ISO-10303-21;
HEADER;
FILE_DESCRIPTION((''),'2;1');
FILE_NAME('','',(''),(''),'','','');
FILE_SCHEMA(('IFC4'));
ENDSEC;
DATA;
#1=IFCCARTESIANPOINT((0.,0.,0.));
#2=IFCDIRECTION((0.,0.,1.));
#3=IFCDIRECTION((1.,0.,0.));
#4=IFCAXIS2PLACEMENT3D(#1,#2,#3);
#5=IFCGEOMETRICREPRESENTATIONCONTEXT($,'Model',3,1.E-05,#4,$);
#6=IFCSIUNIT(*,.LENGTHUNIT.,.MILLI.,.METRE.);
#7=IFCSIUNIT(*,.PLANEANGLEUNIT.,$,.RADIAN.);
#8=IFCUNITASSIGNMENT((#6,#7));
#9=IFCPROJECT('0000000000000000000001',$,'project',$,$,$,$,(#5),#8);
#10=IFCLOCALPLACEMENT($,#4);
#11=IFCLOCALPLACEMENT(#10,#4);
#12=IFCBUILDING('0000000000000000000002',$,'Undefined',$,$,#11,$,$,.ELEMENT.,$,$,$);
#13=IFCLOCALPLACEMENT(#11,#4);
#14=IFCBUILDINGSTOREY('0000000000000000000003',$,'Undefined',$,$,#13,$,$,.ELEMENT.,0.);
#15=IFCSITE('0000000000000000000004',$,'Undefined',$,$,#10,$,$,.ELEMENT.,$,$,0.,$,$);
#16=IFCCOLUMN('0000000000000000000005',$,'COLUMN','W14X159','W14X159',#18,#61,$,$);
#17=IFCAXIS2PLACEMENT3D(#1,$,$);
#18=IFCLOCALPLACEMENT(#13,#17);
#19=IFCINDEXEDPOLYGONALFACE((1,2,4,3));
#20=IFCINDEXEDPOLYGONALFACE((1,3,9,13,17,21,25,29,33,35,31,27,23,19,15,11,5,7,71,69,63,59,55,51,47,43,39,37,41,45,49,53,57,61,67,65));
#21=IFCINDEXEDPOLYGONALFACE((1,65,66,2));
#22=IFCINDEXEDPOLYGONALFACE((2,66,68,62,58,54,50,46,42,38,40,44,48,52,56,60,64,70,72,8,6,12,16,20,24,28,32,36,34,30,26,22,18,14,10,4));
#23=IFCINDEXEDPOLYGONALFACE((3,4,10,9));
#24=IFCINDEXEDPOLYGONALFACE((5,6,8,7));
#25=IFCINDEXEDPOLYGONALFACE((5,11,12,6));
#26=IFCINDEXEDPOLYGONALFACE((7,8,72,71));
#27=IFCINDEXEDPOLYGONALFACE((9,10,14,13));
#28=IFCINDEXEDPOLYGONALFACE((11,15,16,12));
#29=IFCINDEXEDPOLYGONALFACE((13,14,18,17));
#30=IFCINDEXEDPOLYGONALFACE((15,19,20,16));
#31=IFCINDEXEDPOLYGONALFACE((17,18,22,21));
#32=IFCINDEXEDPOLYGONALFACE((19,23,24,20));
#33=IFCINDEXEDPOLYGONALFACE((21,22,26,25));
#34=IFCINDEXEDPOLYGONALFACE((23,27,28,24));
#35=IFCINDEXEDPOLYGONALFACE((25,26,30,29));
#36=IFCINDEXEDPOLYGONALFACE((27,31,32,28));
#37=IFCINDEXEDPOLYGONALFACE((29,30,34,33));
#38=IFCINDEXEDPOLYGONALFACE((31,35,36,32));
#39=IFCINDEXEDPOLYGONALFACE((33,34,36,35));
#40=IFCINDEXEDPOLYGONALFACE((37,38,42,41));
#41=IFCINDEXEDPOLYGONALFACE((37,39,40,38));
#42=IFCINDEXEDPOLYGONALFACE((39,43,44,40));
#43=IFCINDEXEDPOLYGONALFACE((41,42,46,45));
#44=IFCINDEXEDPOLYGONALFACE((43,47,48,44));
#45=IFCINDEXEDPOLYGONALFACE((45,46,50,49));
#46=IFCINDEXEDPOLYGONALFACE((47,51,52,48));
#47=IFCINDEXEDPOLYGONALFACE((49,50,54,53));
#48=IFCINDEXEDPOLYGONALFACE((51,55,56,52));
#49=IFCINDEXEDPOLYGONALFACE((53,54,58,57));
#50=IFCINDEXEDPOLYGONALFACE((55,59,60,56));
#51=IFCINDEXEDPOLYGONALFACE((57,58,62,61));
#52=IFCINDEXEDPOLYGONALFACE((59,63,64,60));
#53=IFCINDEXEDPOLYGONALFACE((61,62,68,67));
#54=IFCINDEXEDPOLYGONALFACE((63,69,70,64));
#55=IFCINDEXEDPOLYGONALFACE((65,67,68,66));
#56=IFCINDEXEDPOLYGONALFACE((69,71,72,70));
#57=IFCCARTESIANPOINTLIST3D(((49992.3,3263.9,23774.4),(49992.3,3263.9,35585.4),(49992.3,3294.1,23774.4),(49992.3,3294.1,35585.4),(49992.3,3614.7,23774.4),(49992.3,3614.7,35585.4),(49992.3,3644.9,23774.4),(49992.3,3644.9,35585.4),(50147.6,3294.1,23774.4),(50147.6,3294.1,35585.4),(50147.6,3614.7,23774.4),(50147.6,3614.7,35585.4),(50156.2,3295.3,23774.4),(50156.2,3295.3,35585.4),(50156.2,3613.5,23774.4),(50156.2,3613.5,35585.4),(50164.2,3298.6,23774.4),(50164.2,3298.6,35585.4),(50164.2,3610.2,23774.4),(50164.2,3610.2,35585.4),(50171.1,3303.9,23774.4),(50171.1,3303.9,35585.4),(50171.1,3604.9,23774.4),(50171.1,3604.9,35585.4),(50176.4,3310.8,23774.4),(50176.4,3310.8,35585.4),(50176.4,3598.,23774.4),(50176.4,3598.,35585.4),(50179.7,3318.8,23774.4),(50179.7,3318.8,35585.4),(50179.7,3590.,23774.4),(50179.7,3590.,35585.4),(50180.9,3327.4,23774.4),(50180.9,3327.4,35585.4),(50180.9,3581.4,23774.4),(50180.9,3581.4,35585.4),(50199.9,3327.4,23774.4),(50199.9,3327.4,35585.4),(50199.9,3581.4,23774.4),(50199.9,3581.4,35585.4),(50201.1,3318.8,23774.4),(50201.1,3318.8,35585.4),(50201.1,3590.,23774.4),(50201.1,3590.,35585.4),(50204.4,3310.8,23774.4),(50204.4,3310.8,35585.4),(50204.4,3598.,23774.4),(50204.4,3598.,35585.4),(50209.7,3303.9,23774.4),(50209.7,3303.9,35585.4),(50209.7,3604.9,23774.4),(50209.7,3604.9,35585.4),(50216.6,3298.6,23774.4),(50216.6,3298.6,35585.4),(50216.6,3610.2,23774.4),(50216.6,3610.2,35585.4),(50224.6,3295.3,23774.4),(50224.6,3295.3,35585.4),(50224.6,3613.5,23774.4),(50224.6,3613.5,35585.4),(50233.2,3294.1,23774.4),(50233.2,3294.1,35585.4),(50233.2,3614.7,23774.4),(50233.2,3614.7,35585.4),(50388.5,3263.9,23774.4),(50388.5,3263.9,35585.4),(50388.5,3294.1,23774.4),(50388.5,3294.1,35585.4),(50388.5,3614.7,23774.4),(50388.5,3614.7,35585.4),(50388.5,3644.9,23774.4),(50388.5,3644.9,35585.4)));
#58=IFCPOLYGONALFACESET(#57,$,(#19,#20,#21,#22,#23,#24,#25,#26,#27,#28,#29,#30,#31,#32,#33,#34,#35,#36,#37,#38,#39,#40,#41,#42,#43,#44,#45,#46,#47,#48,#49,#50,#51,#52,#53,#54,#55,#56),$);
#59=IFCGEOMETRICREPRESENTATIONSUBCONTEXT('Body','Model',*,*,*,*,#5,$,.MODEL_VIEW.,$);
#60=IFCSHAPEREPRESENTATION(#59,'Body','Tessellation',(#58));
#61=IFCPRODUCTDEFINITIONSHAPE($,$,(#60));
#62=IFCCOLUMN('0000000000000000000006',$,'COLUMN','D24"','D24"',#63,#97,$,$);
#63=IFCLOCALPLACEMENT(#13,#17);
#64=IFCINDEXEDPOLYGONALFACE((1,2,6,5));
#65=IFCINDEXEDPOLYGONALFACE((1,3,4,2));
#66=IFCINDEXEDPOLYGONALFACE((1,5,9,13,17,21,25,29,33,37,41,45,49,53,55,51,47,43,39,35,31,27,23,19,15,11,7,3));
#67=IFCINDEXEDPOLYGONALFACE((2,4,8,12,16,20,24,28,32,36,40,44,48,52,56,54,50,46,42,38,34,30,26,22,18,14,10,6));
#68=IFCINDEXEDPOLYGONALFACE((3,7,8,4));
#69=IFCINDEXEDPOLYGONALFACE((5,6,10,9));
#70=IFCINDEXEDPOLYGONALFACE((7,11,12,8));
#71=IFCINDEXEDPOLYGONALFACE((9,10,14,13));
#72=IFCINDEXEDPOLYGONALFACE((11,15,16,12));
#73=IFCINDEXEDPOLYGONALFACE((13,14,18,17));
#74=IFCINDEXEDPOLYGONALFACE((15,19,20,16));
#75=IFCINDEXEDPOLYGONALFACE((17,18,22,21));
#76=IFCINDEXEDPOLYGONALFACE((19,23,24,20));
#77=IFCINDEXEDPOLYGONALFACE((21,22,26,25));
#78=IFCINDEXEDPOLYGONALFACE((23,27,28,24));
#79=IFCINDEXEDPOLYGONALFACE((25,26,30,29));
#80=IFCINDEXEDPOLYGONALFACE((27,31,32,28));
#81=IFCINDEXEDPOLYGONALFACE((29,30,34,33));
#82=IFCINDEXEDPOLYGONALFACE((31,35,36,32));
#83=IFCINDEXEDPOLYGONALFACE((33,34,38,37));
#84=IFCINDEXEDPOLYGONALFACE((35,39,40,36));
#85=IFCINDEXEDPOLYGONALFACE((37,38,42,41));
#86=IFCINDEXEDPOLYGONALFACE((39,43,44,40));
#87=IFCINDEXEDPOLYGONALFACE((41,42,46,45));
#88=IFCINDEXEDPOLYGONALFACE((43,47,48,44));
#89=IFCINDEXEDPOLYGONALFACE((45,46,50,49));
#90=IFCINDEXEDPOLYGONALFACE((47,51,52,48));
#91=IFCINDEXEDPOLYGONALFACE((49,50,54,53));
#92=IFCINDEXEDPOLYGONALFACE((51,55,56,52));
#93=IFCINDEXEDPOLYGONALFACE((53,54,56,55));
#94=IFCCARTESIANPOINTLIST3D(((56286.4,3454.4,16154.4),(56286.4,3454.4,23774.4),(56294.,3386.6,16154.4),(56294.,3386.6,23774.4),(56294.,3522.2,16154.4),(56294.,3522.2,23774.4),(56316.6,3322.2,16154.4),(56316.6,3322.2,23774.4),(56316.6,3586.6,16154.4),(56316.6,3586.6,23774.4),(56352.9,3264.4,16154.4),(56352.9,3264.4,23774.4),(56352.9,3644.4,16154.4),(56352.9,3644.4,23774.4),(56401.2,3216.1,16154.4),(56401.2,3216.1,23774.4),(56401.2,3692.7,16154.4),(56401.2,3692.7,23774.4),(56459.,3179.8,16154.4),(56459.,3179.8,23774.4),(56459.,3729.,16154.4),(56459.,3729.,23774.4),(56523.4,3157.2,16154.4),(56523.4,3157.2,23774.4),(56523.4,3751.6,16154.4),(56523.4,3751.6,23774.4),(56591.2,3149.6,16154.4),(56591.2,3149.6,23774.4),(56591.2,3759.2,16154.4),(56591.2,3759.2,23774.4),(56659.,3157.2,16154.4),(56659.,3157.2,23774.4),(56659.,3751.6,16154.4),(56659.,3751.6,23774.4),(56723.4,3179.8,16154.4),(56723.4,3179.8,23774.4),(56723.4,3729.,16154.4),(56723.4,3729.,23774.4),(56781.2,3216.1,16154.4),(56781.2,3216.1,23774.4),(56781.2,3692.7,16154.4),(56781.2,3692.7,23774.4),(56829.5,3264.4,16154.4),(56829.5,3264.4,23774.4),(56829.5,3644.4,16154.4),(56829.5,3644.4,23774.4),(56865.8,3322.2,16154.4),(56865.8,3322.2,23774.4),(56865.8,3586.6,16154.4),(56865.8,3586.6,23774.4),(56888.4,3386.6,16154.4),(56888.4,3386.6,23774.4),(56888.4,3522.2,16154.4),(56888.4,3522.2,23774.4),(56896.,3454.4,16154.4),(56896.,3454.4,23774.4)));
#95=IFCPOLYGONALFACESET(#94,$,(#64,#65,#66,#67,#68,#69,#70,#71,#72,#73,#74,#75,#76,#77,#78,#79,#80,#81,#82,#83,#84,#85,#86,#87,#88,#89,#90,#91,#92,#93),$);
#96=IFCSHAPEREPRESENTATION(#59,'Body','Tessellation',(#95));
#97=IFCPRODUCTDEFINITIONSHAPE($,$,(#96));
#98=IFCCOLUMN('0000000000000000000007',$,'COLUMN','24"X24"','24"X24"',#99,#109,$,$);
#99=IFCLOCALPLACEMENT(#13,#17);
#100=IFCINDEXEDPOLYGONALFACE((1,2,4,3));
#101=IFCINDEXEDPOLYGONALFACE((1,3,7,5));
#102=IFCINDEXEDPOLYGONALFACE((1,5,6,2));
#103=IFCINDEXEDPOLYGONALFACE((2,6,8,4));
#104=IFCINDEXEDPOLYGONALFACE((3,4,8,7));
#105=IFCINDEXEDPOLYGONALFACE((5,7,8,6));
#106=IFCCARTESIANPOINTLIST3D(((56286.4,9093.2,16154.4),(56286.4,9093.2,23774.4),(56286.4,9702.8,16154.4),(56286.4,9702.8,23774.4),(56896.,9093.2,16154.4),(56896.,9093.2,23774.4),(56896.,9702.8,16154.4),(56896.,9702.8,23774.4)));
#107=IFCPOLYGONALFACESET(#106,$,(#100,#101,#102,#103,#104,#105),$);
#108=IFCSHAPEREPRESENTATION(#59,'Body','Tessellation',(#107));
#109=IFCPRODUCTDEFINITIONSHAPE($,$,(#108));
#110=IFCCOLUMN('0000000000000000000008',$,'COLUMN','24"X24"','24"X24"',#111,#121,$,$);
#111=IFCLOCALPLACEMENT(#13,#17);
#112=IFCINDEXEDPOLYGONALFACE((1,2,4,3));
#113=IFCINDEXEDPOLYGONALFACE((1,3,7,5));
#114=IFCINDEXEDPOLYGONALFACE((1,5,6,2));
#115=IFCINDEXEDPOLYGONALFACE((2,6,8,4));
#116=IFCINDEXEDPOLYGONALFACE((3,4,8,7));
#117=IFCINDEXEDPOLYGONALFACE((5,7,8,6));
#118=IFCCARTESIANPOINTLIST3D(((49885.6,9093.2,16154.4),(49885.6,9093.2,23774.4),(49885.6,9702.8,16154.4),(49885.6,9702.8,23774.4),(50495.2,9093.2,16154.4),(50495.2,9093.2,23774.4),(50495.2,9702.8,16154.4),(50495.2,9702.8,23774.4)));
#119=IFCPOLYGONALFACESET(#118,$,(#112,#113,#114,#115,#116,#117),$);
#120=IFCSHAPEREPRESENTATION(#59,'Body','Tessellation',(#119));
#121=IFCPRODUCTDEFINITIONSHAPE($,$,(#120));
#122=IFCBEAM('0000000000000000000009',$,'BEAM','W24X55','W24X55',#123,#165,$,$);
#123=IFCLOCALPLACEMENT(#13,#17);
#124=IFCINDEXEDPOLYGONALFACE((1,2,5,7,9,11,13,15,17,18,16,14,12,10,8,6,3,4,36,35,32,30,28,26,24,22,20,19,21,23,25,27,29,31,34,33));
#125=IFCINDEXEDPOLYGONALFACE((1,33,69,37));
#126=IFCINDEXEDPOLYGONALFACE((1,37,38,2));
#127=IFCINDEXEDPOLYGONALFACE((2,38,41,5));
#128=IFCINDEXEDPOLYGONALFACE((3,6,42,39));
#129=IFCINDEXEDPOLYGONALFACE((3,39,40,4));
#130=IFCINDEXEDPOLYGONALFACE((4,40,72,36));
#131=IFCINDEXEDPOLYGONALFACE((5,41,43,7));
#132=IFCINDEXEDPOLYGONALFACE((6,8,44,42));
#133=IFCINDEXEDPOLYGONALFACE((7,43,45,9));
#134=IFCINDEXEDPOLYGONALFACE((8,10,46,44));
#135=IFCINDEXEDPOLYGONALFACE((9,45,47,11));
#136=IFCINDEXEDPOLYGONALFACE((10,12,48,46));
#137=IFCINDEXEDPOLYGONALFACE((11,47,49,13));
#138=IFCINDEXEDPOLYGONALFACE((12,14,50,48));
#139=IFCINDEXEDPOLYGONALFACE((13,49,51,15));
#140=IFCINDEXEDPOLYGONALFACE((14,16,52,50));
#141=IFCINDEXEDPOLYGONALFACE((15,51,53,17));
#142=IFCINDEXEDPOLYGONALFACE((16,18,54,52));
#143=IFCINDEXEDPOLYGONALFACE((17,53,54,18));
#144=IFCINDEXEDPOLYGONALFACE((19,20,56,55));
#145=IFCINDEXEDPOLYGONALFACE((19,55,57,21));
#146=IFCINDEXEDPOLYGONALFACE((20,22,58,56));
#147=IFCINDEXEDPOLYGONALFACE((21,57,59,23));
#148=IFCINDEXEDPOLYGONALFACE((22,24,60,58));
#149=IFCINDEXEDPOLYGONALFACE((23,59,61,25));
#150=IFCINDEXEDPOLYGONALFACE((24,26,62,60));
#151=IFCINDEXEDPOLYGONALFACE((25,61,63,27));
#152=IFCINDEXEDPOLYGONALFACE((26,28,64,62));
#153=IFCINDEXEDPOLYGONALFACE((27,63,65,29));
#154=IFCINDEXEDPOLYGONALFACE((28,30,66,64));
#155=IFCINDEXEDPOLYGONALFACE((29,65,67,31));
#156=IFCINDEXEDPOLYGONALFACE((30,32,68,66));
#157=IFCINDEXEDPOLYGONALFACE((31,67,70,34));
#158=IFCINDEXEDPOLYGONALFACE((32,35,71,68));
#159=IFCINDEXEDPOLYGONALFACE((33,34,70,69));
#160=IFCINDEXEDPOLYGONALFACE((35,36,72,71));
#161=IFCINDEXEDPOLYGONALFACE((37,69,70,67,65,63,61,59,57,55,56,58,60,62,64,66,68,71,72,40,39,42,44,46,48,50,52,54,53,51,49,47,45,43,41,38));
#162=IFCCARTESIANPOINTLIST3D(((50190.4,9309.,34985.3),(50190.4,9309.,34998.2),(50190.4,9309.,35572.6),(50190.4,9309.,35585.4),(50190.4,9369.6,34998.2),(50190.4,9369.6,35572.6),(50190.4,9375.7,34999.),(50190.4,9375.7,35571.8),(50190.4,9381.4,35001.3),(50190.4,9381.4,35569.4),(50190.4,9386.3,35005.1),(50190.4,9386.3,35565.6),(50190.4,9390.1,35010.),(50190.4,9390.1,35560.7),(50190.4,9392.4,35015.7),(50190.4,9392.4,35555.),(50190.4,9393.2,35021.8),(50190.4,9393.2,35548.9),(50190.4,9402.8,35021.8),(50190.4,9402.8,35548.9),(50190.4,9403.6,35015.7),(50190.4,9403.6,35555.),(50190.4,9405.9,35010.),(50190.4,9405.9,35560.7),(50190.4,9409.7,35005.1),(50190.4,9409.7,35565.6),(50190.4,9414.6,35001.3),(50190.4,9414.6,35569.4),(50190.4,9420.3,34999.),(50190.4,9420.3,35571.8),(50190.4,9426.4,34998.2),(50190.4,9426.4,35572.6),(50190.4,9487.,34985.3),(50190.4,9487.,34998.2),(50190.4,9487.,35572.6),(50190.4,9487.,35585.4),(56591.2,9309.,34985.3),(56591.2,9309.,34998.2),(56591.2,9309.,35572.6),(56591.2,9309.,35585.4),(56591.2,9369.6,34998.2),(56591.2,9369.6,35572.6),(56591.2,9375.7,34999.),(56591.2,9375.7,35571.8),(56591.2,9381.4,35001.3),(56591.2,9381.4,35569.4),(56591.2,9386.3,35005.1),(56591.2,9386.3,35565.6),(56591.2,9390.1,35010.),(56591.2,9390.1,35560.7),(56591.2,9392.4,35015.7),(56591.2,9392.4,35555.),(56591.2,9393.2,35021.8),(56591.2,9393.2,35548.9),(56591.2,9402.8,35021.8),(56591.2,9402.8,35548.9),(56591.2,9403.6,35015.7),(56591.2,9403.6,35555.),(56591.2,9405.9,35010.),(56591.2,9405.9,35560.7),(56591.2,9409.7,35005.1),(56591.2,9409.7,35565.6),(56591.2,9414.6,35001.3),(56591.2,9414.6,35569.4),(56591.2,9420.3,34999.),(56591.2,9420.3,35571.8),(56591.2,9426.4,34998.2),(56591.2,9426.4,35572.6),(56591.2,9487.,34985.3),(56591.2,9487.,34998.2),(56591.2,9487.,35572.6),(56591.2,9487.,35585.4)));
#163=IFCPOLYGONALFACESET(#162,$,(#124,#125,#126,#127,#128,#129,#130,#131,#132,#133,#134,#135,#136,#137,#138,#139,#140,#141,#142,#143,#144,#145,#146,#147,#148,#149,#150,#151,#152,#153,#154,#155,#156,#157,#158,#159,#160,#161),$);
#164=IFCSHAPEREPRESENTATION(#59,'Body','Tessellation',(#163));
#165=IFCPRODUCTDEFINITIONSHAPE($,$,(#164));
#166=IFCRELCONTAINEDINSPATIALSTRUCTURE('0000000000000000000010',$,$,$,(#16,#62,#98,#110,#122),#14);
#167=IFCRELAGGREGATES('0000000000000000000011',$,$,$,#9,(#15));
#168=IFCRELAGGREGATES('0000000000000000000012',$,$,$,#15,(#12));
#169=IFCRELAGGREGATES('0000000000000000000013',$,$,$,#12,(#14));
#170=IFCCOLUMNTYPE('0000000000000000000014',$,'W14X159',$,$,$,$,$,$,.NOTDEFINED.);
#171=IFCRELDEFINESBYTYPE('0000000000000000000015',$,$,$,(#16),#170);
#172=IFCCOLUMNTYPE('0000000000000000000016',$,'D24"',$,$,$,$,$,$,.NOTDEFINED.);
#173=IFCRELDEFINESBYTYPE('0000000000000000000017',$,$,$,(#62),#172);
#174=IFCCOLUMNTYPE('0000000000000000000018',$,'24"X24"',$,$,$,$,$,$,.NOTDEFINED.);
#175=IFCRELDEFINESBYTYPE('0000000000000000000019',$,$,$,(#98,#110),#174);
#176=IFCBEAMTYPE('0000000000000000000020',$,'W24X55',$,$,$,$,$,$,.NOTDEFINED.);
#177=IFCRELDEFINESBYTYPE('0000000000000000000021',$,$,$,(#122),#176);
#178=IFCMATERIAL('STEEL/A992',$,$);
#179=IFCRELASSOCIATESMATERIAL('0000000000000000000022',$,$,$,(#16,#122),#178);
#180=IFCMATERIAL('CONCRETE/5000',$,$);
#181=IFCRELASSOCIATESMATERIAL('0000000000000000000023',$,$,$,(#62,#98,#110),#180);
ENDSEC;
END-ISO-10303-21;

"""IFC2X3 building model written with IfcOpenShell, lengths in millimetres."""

from ifc_helpers import new_model, si_unit, frame, origin_with_axes, origin_2d_with_axis, place, context, subcontext, project, spatial, rectangle, circle, i_section, extrude, material, type_object, element, save


model = new_model("IFC2X3")

# Units and contexts
model_context = context("Model", 3, precision=1e-05, world=origin_with_axes())
body_context = subcontext(model_context, "Body", "Model", "MODEL_VIEW")
ifc_project = project(units=[si_unit("LENGTHUNIT", "METRE", prefix="MILLI"), si_unit("PLANEANGLEUNIT", "RADIAN")], contexts=[model_context])

# Site, building, storey
site_placement = place(None, origin_with_axes())
site = spatial("IfcSite", under=ifc_project, at=site_placement, Name="Undefined", CompositionType="ELEMENT", RefElevation=0.0)
building_placement = place(site_placement, origin_with_axes())
building = spatial("IfcBuilding", under=site, at=building_placement, Name="Undefined", CompositionType="ELEMENT")
storey_placement = place(building_placement, origin_with_axes())
storey = spatial("IfcBuildingStorey", under=building, at=storey_placement, Name="Undefined", CompositionType="ELEMENT", Elevation=0.0)

# Columns
ifc_material_1 = material(Name="STEEL/A992")
column_type_1 = type_object("IfcColumnType", Name="W14X159", PredefinedType="NOTDEFINED")
column_1_placement = place(storey_placement, frame((50190.4, 3454.4, 23774.4), z_axis=(0.0, 0.0, 1.0), x_axis=(1.0, 0.0, 0.0)))
element("IfcColumn", 1, at=column_1_placement, inside=storey, type_object=column_type_1, material=ifc_material_1, Name="COLUMN", Description="W14X159", ObjectType="W14X159", context=body_context, shape_type="SweptSolid", body=[
    extrude(i_section(OverallWidth=396.2, OverallDepth=381.0, WebThickness=19.0, FlangeThickness=30.2, FilletRadius=33.3, at=origin_2d_with_axis()), frame((0.0, 0.0, 11811.0), z_axis=(0.0, 0.0, -1.0), x_axis=(-1.0, 0.0, 0.0)), (0.0, 0.0, 1.0), 11811.0),
])
ifc_material_2 = material(Name="CONCRETE/5000")
column_type_2 = type_object("IfcColumnType", Name="D24\"", PredefinedType="NOTDEFINED")
column_2_placement = place(storey_placement, frame((56591.2, 3454.4, 16154.4), z_axis=(0.0, 0.0, 1.0), x_axis=(1.0, 0.0, 0.0)))
element("IfcColumn", 2, at=column_2_placement, inside=storey, type_object=column_type_2, material=ifc_material_2, Name="COLUMN", Description="D24\"", ObjectType="D24\"", context=body_context, shape_type="SweptSolid", body=[
    extrude(circle(Radius=304.8, at=origin_2d_with_axis()), frame((0.0, 0.0, 7620.0), z_axis=(0.0, 0.0, -1.0), x_axis=(0.0, -1.0, 0.0)), (0.0, 0.0, 1.0), 7620.0),
])
column_type_3 = type_object("IfcColumnType", Name="24\"X24\"", PredefinedType="NOTDEFINED")
for number, where, z_axis, x_axis, name in (
    (3, (56591.2, 9398.0, 16154.4), (0.0, 0.0, 1.0), (1.0, 0.0, 0.0), "COLUMN"),
    (4, (50190.4, 9398.0, 16154.4), (0.0, 0.0, 1.0), (1.0, 0.0, 0.0), "COLUMN"),
):
    element("IfcColumn", number, at=place(storey_placement, frame(where, z_axis=z_axis, x_axis=x_axis)), inside=storey, type_object=column_type_3, material=ifc_material_2, Name=name, Description="24\"X24\"", ObjectType="24\"X24\"", context=body_context, shape_type="SweptSolid", body=[
        extrude(rectangle(XDim=609.6, YDim=609.6, at=origin_2d_with_axis()), frame((0.0, 0.0, 7620.0), z_axis=(0.0, 0.0, -1.0), x_axis=(0.0, -1.0, 0.0)), (0.0, 0.0, 1.0), 7620.0),
    ])

# Beam
beam_type_1 = type_object("IfcBeamType", Name="W24X55", PredefinedType="NOTDEFINED")
beam_1_placement = place(storey_placement, frame((50190.4, 9398.0, 35285.4), z_axis=(0.0, 0.0, 1.0), x_axis=(1.0, 0.0, 0.0)))
element("IfcBeam", 5, at=beam_1_placement, inside=storey, type_object=beam_type_1, material=ifc_material_1, Name="BEAM", Description="W24X55", ObjectType="W24X55", context=body_context, shape_type="SweptSolid", body=[
    extrude(i_section(OverallWidth=178.1, OverallDepth=600.1, WebThickness=9.5, FlangeThickness=12.8, FilletRadius=23.7, at=origin_2d_with_axis()), frame((6400.8, 0.0, 0.0), z_axis=(-1.0, 0.0, 0.0), x_axis=(0.0, -1.0, 0.0)), (0.0, 0.0, 1.0), 6400.8),
])

save(model, "model.ifc")
